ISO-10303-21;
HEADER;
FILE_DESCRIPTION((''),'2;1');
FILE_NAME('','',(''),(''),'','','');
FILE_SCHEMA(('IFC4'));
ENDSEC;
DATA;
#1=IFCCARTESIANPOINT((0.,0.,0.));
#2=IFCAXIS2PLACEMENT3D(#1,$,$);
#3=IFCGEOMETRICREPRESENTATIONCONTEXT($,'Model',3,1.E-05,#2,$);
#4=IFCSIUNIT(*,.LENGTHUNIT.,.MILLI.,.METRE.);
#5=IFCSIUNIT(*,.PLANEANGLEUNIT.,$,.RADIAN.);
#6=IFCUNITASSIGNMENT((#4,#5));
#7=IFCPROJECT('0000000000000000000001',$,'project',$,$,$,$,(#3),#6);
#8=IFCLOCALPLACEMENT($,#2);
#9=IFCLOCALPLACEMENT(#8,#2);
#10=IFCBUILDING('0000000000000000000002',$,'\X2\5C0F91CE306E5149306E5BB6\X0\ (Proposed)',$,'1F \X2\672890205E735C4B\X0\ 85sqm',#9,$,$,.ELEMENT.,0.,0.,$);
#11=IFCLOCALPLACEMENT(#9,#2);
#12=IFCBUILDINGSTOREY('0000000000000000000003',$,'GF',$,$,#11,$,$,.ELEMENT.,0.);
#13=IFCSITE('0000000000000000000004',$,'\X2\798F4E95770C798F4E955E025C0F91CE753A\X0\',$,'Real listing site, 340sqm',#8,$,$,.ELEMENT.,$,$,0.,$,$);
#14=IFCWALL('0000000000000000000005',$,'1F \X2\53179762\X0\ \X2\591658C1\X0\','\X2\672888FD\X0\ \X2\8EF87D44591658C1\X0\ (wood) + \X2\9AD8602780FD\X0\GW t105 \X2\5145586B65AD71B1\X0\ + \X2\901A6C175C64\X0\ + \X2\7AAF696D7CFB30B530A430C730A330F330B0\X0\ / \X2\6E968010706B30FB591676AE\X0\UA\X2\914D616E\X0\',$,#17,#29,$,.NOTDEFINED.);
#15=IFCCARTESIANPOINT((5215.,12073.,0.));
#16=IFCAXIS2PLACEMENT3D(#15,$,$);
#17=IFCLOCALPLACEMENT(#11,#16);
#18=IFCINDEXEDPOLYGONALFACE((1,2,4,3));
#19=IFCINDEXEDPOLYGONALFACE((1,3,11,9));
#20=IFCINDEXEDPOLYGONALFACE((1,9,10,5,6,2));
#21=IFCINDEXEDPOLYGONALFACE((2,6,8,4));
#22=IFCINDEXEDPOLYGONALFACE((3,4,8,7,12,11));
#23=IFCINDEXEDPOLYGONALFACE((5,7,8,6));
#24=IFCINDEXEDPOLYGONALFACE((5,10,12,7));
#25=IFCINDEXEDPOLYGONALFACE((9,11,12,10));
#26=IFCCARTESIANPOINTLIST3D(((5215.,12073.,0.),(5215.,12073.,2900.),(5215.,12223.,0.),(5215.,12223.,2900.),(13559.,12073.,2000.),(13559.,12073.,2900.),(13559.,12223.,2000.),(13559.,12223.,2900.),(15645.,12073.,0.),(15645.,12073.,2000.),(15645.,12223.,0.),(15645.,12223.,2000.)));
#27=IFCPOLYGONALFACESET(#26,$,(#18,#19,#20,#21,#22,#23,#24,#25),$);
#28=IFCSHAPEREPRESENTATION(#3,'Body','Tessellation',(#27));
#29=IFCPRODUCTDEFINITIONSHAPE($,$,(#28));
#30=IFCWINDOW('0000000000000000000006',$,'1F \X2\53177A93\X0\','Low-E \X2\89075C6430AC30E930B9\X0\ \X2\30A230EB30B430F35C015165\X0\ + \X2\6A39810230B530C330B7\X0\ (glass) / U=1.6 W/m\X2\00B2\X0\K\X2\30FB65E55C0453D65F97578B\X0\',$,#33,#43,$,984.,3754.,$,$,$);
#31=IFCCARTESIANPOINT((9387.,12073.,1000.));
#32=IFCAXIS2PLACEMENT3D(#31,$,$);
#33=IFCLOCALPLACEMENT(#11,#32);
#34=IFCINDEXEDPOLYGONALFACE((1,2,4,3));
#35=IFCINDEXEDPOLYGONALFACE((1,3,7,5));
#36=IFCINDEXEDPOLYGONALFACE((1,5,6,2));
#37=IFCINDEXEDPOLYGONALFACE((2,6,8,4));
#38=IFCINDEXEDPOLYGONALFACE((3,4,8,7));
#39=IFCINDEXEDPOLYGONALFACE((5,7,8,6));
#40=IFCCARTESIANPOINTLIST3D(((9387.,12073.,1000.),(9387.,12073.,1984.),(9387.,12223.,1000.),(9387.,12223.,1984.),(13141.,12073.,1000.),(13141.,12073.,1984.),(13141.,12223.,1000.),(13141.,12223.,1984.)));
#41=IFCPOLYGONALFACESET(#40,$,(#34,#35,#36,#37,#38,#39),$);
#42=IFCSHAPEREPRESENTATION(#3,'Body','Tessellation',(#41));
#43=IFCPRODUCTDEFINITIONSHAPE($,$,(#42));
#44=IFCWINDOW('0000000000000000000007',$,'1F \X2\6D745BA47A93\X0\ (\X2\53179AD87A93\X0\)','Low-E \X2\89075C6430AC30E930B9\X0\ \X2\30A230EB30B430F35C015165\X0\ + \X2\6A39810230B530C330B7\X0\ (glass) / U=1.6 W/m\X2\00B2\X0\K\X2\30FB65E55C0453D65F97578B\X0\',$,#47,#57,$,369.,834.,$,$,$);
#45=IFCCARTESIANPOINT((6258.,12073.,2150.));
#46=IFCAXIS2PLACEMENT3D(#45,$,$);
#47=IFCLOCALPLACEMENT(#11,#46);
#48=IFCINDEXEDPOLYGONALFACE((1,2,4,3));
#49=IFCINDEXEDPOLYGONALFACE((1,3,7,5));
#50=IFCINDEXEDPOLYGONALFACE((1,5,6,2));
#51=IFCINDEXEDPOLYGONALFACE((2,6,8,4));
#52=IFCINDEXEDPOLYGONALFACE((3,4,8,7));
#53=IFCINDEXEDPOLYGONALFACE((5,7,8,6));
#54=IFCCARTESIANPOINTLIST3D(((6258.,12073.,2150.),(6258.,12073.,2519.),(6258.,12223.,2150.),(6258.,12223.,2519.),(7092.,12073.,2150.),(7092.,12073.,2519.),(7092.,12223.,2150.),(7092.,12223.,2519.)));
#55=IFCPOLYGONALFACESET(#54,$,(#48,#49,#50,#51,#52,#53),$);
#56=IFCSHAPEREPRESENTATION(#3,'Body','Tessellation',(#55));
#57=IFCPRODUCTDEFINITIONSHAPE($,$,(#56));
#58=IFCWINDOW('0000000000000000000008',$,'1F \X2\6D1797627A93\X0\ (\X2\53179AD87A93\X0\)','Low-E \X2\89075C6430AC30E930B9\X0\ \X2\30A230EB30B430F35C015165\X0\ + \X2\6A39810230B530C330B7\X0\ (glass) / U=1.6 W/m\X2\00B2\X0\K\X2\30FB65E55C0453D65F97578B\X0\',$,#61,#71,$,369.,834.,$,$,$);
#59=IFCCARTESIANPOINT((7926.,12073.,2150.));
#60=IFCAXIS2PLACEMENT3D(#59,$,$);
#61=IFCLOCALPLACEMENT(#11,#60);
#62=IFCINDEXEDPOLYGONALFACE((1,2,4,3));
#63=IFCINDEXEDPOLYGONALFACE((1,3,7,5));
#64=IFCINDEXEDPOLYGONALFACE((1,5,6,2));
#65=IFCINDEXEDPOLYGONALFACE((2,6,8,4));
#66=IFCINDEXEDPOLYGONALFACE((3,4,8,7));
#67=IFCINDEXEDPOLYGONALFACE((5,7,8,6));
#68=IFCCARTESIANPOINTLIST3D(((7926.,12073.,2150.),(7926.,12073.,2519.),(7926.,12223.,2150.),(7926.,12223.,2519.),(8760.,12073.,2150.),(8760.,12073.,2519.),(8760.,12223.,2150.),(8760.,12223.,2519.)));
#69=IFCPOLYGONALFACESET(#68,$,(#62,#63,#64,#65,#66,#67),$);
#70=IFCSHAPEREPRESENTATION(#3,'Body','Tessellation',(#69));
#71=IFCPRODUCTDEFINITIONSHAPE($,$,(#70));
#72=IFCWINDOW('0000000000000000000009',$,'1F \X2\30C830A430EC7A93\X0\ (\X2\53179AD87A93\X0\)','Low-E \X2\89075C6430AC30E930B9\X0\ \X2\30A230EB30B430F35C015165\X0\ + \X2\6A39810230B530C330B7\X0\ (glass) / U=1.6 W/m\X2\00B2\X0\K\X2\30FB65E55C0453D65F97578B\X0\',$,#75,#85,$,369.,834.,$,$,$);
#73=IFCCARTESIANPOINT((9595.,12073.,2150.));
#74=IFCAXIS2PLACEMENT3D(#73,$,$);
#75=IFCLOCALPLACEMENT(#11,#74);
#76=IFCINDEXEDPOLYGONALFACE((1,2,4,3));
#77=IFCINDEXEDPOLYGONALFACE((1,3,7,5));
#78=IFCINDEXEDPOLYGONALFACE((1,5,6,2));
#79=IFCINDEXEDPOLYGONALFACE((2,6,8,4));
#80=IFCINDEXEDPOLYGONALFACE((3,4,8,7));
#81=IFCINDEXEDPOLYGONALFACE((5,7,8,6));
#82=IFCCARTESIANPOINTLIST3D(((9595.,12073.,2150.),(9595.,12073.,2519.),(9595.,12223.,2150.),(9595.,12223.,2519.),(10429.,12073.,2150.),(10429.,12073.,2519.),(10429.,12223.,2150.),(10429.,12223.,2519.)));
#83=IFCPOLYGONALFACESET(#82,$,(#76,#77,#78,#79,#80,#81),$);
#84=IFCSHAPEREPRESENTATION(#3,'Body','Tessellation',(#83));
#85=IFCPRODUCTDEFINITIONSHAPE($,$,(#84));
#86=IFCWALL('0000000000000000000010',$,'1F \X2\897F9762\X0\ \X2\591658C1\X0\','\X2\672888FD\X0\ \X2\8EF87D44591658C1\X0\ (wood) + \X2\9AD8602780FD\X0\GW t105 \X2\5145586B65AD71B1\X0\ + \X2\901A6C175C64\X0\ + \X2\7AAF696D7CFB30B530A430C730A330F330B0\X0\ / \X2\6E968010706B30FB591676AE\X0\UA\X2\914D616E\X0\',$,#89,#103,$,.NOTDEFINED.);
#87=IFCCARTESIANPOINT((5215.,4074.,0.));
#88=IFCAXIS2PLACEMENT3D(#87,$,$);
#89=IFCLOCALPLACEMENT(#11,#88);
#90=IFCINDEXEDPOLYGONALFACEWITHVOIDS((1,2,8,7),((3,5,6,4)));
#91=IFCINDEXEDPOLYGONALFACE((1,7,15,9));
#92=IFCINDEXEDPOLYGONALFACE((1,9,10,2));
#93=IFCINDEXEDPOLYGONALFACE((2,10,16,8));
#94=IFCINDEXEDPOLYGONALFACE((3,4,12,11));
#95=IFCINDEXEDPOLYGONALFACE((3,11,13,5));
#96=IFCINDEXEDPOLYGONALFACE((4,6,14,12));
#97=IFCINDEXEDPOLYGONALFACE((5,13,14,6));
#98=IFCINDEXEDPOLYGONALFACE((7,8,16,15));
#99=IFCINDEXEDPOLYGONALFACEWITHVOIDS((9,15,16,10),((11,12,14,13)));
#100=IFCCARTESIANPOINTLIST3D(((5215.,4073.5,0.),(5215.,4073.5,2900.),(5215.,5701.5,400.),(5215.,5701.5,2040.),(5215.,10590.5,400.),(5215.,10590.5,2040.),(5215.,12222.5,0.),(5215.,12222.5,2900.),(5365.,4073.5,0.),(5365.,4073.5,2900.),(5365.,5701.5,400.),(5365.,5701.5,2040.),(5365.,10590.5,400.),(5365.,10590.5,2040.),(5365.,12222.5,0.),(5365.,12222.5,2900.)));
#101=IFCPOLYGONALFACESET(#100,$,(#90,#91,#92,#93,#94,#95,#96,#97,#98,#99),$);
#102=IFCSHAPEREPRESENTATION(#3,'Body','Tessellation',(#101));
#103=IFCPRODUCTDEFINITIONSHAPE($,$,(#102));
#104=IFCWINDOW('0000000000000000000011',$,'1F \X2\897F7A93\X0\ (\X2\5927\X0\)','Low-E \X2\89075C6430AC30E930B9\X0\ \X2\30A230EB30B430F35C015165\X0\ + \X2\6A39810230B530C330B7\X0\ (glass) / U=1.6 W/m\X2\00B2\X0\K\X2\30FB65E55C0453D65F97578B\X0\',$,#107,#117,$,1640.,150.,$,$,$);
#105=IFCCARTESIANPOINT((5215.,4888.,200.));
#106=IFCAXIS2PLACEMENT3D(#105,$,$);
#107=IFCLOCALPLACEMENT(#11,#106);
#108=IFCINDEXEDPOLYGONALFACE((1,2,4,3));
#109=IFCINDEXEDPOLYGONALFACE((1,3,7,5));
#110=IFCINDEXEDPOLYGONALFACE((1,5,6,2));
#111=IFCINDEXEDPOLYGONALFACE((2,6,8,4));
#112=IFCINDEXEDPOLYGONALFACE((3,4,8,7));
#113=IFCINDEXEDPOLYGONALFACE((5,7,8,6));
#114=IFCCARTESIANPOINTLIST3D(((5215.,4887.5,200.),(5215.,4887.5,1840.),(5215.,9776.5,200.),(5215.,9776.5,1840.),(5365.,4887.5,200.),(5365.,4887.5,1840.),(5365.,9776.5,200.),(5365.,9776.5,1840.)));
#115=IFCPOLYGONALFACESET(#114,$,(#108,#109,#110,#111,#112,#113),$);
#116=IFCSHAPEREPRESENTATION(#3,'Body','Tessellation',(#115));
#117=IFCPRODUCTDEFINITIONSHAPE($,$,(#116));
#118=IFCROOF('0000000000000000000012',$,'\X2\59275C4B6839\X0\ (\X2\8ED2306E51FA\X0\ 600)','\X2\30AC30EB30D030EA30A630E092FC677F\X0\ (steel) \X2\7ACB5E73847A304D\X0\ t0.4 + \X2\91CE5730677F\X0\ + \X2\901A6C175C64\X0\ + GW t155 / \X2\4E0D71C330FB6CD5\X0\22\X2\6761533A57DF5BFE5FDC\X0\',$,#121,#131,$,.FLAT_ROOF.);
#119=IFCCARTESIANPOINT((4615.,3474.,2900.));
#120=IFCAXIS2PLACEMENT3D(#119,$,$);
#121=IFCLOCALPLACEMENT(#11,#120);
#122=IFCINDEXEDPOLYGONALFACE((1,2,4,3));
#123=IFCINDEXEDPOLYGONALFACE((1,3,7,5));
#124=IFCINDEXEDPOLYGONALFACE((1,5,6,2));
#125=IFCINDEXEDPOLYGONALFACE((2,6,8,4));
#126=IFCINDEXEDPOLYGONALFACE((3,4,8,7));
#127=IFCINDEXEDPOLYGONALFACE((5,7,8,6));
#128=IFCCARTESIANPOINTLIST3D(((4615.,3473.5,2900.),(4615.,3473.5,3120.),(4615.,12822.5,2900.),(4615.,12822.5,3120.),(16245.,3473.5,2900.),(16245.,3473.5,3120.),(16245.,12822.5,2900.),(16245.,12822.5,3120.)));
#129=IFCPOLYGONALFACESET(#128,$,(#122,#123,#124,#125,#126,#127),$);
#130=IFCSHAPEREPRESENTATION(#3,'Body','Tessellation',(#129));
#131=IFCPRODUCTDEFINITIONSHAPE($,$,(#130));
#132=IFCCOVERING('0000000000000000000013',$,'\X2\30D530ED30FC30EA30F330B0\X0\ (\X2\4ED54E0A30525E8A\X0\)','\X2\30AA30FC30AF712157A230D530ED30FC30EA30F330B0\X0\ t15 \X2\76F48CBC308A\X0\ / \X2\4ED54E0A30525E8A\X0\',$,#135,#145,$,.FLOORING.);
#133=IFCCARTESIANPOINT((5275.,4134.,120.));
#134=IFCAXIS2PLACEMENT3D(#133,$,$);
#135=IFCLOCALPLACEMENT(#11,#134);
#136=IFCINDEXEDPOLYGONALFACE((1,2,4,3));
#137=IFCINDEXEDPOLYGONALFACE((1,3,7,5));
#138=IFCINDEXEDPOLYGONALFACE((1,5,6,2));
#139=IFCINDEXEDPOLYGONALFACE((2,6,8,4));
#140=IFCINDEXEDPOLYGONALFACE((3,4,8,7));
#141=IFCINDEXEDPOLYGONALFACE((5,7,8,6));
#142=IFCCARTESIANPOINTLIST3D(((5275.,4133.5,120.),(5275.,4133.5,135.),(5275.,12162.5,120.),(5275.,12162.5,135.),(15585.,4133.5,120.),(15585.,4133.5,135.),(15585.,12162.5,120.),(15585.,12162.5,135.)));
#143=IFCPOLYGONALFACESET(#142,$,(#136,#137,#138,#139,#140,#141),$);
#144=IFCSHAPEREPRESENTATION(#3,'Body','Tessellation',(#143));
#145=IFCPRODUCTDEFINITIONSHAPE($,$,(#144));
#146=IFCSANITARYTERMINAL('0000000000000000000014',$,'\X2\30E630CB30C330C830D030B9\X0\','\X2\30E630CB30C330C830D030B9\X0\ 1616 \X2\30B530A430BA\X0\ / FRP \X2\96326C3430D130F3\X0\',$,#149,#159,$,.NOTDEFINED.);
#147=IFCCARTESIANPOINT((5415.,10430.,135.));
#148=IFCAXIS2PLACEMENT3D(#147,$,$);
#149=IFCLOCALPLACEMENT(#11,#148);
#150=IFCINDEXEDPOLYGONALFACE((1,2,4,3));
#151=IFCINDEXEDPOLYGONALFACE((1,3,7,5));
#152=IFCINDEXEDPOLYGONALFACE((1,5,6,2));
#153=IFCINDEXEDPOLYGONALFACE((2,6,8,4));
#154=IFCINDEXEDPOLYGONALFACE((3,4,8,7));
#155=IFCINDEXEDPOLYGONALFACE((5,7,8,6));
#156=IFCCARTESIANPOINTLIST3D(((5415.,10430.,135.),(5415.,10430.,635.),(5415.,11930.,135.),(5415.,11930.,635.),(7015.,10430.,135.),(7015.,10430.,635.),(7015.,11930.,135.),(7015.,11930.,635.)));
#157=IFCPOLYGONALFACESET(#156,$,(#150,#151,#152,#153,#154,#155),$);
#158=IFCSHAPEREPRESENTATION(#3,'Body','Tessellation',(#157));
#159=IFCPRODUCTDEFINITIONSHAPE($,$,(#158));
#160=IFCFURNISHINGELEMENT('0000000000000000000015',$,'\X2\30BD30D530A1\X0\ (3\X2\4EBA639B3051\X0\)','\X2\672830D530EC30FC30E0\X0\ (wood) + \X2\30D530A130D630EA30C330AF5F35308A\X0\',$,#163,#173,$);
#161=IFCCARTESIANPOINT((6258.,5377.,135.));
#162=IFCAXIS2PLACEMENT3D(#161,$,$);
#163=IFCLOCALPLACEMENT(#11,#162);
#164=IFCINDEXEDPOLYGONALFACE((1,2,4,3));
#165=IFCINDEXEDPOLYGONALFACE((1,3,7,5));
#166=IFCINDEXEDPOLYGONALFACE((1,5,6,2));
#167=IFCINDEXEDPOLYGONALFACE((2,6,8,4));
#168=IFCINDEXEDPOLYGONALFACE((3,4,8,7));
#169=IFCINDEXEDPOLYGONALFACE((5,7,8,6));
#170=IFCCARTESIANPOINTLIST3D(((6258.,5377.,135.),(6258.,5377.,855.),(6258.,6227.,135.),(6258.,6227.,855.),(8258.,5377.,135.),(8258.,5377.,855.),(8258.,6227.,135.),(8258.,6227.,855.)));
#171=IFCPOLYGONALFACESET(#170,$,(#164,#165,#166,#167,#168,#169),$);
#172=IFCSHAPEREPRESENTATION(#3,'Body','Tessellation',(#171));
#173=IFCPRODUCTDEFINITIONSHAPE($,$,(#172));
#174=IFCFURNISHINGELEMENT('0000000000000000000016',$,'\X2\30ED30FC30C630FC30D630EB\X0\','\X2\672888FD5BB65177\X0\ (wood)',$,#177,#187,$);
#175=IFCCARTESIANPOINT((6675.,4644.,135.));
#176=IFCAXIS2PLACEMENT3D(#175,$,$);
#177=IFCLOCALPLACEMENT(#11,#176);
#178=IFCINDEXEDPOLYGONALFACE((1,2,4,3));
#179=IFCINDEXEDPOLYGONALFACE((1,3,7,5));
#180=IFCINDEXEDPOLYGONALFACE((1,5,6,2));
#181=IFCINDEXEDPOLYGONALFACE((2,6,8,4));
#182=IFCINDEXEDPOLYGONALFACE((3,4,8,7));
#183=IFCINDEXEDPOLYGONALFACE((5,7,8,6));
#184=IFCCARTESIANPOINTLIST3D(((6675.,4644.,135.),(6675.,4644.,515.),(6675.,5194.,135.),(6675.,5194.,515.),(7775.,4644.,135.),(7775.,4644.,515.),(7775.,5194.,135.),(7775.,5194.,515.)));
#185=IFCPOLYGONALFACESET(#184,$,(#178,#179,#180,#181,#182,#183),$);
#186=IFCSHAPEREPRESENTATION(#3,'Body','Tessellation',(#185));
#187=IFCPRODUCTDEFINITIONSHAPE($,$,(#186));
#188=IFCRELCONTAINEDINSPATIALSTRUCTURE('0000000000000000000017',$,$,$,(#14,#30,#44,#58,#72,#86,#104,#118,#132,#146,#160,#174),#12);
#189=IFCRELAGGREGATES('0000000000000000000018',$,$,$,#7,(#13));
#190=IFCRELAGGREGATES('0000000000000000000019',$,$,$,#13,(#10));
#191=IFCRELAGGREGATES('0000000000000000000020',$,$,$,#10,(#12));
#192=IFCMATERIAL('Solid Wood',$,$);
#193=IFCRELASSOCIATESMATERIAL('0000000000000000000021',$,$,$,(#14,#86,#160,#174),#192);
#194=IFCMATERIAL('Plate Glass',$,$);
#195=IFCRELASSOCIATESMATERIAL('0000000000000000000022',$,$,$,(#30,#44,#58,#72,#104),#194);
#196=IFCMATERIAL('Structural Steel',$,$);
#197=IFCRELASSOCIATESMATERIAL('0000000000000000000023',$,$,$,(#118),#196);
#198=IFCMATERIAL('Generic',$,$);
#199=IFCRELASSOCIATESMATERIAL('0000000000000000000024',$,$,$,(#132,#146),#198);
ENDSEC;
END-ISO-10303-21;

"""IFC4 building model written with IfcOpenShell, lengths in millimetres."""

from ifc_helpers import new_model, si_unit, frame, frame_2d, origin, place, context, project, spatial, rectangle, extrude, material, element, fill, save


model = new_model("IFC4")

# Units and contexts
model_context = context("Model", 3, precision=1e-05, world=origin())
ifc_project = project(units=[si_unit("LENGTHUNIT", "METRE", prefix="MILLI"), si_unit("PLANEANGLEUNIT", "RADIAN")], contexts=[model_context])

# Site, building, storey
site_placement = place(None, origin())
site = spatial("IfcSite", under=ifc_project, at=site_placement, Name="福井県福井市小野町", ObjectType="Real listing site, 340sqm", CompositionType="ELEMENT", RefElevation=0.0)
building_placement = place(site_placement, origin())
building = spatial("IfcBuilding", under=site, at=building_placement, Name="小野の光の家 (Proposed)", ObjectType="1F 木造平屋 85sqm", CompositionType="ELEMENT", ElevationOfRefHeight=0.0, ElevationOfTerrain=0.0)
storey_placement = place(building_placement, origin())
storey = spatial("IfcBuildingStorey", under=building, at=storey_placement, Name="GF", CompositionType="ELEMENT", Elevation=0.0)

# Shared definitions
ifc_material_1 = material(Name="Solid Wood")

# Shared definitions
ifc_material_2 = material(Name="Plate Glass")

# Wall, openings, windows
wall_1_placement = place(storey_placement, frame((5215.0, 12073.0, 0.0)))
wall_1 = element("IfcWall", 1, at=wall_1_placement, inside=storey, material=ifc_material_1, Name="1F 北面 外壁", Description="木製 軸組外壁 (wood) + 高性能GW t105 充填断熱 + 通気層 + 窯業系サイディング / 準耐火・外皮UA配慮", PredefinedType="NOTDEFINED", context=model_context, shape_type="SweptSolid", body=[
    extrude(rectangle(XDim=10430.0, YDim=150.0, at=frame_2d((5215.0, 75.0))), frame((5215.0, 12073.0, 0.0)), (0.0, 0.0, 1.0), 2900.0),
])
opening_1_placement = place(storey_placement, frame((9387.0, 12073.0, 1000.0)))
opening_1 = element("IfcOpeningElement", 2, at=opening_1_placement, cuts=wall_1, PredefinedType="NOTDEFINED", context=model_context, shape_type="SweptSolid", body=[
    extrude(rectangle(XDim=3754.0, YDim=150.0, at=frame_2d((1877.0, 75.0))), frame((9387.0, 12073.0, 1000.0)), (0.0, 0.0, 1.0), 984.0),
])
opening_2_placement = place(storey_placement, frame((6258.0, 12073.0, 2150.0)))
opening_2 = element("IfcOpeningElement", 3, at=opening_2_placement, cuts=wall_1, PredefinedType="NOTDEFINED", context=model_context, shape_type="SweptSolid", body=[
    extrude(rectangle(XDim=834.0, YDim=150.0, at=frame_2d((417.0, 75.0))), frame((6258.0, 12073.0, 2150.0)), (0.0, 0.0, 1.0), 369.0),
])
opening_3_placement = place(storey_placement, frame((7926.0, 12073.0, 2150.0)))
opening_3 = element("IfcOpeningElement", 4, at=opening_3_placement, cuts=wall_1, PredefinedType="NOTDEFINED", context=model_context, shape_type="SweptSolid", body=[
    extrude(rectangle(XDim=834.0, YDim=150.0, at=frame_2d((417.0, 75.0))), frame((7926.0, 12073.0, 2150.0)), (0.0, 0.0, 1.0), 369.0),
])
opening_4_placement = place(storey_placement, frame((9595.0, 12073.0, 2150.0)))
opening_4 = element("IfcOpeningElement", 5, at=opening_4_placement, cuts=wall_1, PredefinedType="NOTDEFINED", context=model_context, shape_type="SweptSolid", body=[
    extrude(rectangle(XDim=834.0, YDim=150.0, at=frame_2d((417.0, 75.0))), frame((9595.0, 12073.0, 2150.0)), (0.0, 0.0, 1.0), 369.0),
])
window_1_placement = place(storey_placement, frame((9387.0, 12073.0, 1000.0)))
window_1 = element("IfcWindow", 6, at=window_1_placement, inside=storey, material=ifc_material_2, Name="1F 北窓", Description="Low-E 複層ガラス アルゴン封入 + 樹脂サッシ (glass) / U=1.6 W/m²K・日射取得型", OverallHeight=984.0, OverallWidth=3754.0, context=model_context, shape_type="SweptSolid", body=[
    extrude(rectangle(XDim=3754.0, YDim=150.0, at=frame_2d((1877.0, 75.0))), frame((9387.0, 12073.0, 1000.0)), (0.0, 0.0, 1.0), 984.0),
])
fill(opening_1, window_1)
window_2_placement = place(storey_placement, frame((6258.0, 12073.0, 2150.0)))
window_2 = element("IfcWindow", 7, at=window_2_placement, inside=storey, material=ifc_material_2, Name="1F 浴室窓 (北高窓)", Description="Low-E 複層ガラス アルゴン封入 + 樹脂サッシ (glass) / U=1.6 W/m²K・日射取得型", OverallHeight=369.0, OverallWidth=834.0, context=model_context, shape_type="SweptSolid", body=[
    extrude(rectangle(XDim=834.0, YDim=150.0, at=frame_2d((417.0, 75.0))), frame((6258.0, 12073.0, 2150.0)), (0.0, 0.0, 1.0), 369.0),
])
fill(opening_2, window_2)
window_3_placement = place(storey_placement, frame((7926.0, 12073.0, 2150.0)))
window_3 = element("IfcWindow", 8, at=window_3_placement, inside=storey, material=ifc_material_2, Name="1F 洗面窓 (北高窓)", Description="Low-E 複層ガラス アルゴン封入 + 樹脂サッシ (glass) / U=1.6 W/m²K・日射取得型", OverallHeight=369.0, OverallWidth=834.0, context=model_context, shape_type="SweptSolid", body=[
    extrude(rectangle(XDim=834.0, YDim=150.0, at=frame_2d((417.0, 75.0))), frame((7926.0, 12073.0, 2150.0)), (0.0, 0.0, 1.0), 369.0),
])
fill(opening_3, window_3)
window_4_placement = place(storey_placement, frame((9595.0, 12073.0, 2150.0)))
window_4 = element("IfcWindow", 9, at=window_4_placement, inside=storey, material=ifc_material_2, Name="1F トイレ窓 (北高窓)", Description="Low-E 複層ガラス アルゴン封入 + 樹脂サッシ (glass) / U=1.6 W/m²K・日射取得型", OverallHeight=369.0, OverallWidth=834.0, context=model_context, shape_type="SweptSolid", body=[
    extrude(rectangle(XDim=834.0, YDim=150.0, at=frame_2d((417.0, 75.0))), frame((9595.0, 12073.0, 2150.0)), (0.0, 0.0, 1.0), 369.0),
])
fill(opening_4, window_4)

# Wall, opening, window
wall_2_placement = place(storey_placement, frame((5215.0, 4074.0, 0.0)))
wall_2 = element("IfcWall", 10, at=wall_2_placement, inside=storey, material=ifc_material_1, Name="1F 西面 外壁", Description="木製 軸組外壁 (wood) + 高性能GW t105 充填断熱 + 通気層 + 窯業系サイディング / 準耐火・外皮UA配慮", PredefinedType="NOTDEFINED", context=model_context, shape_type="SweptSolid", body=[
    extrude(rectangle(XDim=150.0, YDim=8149.0, at=frame_2d((75.0, 4074.0))), frame((5215.0, 4074.0, 0.0)), (0.0, 0.0, 1.0), 2900.0),
])
opening_5_placement = place(storey_placement, frame((5215.0, 4888.0, 200.0)))
opening_5 = element("IfcOpeningElement", 11, at=opening_5_placement, cuts=wall_2, PredefinedType="NOTDEFINED", context=model_context, shape_type="SweptSolid", body=[
    extrude(rectangle(XDim=150.0, YDim=4889.0, at=frame_2d((75.0, 2444.0))), frame((5215.0, 4888.0, 200.0)), (0.0, 0.0, 1.0), 1640.0),
])
window_5_placement = place(storey_placement, frame((5215.0, 4888.0, 200.0)))
window_5 = element("IfcWindow", 12, at=window_5_placement, inside=storey, material=ifc_material_2, Name="1F 西窓 (大)", Description="Low-E 複層ガラス アルゴン封入 + 樹脂サッシ (glass) / U=1.6 W/m²K・日射取得型", OverallHeight=1640.0, OverallWidth=150.0, context=model_context, shape_type="SweptSolid", body=[
    extrude(rectangle(XDim=150.0, YDim=4889.0, at=frame_2d((75.0, 2444.0))), frame((5215.0, 4888.0, 200.0)), (0.0, 0.0, 1.0), 1640.0),
])
fill(opening_5, window_5)

# Roof
ifc_material_3 = material(Name="Structural Steel")
roof_placement = place(storey_placement, frame((4615.0, 3474.0, 2900.0)))
element("IfcRoof", 13, at=roof_placement, inside=storey, material=ifc_material_3, Name="大屋根 (軒の出 600)", Description="ガルバリウム鋼板 (steel) 立平葺き t0.4 + 野地板 + 通気層 + GW t155 / 不燃・法22条区域対応", PredefinedType="FLAT_ROOF", context=model_context, shape_type="SweptSolid", body=[
    extrude(rectangle(XDim=11630.0, YDim=9349.0, at=frame_2d((5815.0, 4674.0))), frame((4615.0, 3474.0, 2900.0)), (0.0, 0.0, 1.0), 220.0),
])

# Covering
ifc_material_4 = material(Name="Generic")
covering_placement = place(storey_placement, frame((5275.0, 4134.0, 120.0)))
element("IfcCovering", 14, at=covering_placement, inside=storey, material=ifc_material_4, Name="フローリング (仕上げ床)", Description="オーク無垢フローリング t15 直貼り / 仕上げ床", PredefinedType="FLOORING", context=model_context, shape_type="SweptSolid", body=[
    extrude(rectangle(XDim=10310.0, YDim=8029.0, at=frame_2d((5155.0, 4014.0))), frame((5275.0, 4134.0, 120.0)), (0.0, 0.0, 1.0), 15.0),
])

# Sanitary terminal
sanitary_terminal_placement = place(storey_placement, frame((5415.0, 10430.0, 135.0)))
element("IfcSanitaryTerminal", 15, at=sanitary_terminal_placement, inside=storey, material=ifc_material_4, Name="ユニットバス", Description="ユニットバス 1616 サイズ / FRP 防水パン", PredefinedType="NOTDEFINED", context=model_context, shape_type="SweptSolid", body=[
    extrude(rectangle(XDim=1600.0, YDim=1500.0, at=frame_2d((800.0, 750.0))), frame((5415.0, 10430.0, 135.0)), (0.0, 0.0, 1.0), 500.0),
])

# Furnishing elements
furnishing_1_placement = place(storey_placement, frame((6258.0, 5377.0, 135.0)))
element("IfcFurnishingElement", 16, at=furnishing_1_placement, inside=storey, material=ifc_material_1, Name="ソファ (3人掛け)", Description="木フレーム (wood) + ファブリック張り", context=model_context, shape_type="SweptSolid", body=[
    extrude(rectangle(XDim=2000.0, YDim=850.0, at=frame_2d((1000.0, 425.0))), frame((6258.0, 5377.0, 135.0)), (0.0, 0.0, 1.0), 720.0),
])
furnishing_2_placement = place(storey_placement, frame((6675.0, 4644.0, 135.0)))
element("IfcFurnishingElement", 17, at=furnishing_2_placement, inside=storey, material=ifc_material_1, Name="ローテーブル", Description="木製家具 (wood)", context=model_context, shape_type="SweptSolid", body=[
    extrude(rectangle(XDim=1100.0, YDim=550.0, at=frame_2d((550.0, 275.0))), frame((6675.0, 4644.0, 135.0)), (0.0, 0.0, 1.0), 380.0),
])

save(model, "model.ifc")
